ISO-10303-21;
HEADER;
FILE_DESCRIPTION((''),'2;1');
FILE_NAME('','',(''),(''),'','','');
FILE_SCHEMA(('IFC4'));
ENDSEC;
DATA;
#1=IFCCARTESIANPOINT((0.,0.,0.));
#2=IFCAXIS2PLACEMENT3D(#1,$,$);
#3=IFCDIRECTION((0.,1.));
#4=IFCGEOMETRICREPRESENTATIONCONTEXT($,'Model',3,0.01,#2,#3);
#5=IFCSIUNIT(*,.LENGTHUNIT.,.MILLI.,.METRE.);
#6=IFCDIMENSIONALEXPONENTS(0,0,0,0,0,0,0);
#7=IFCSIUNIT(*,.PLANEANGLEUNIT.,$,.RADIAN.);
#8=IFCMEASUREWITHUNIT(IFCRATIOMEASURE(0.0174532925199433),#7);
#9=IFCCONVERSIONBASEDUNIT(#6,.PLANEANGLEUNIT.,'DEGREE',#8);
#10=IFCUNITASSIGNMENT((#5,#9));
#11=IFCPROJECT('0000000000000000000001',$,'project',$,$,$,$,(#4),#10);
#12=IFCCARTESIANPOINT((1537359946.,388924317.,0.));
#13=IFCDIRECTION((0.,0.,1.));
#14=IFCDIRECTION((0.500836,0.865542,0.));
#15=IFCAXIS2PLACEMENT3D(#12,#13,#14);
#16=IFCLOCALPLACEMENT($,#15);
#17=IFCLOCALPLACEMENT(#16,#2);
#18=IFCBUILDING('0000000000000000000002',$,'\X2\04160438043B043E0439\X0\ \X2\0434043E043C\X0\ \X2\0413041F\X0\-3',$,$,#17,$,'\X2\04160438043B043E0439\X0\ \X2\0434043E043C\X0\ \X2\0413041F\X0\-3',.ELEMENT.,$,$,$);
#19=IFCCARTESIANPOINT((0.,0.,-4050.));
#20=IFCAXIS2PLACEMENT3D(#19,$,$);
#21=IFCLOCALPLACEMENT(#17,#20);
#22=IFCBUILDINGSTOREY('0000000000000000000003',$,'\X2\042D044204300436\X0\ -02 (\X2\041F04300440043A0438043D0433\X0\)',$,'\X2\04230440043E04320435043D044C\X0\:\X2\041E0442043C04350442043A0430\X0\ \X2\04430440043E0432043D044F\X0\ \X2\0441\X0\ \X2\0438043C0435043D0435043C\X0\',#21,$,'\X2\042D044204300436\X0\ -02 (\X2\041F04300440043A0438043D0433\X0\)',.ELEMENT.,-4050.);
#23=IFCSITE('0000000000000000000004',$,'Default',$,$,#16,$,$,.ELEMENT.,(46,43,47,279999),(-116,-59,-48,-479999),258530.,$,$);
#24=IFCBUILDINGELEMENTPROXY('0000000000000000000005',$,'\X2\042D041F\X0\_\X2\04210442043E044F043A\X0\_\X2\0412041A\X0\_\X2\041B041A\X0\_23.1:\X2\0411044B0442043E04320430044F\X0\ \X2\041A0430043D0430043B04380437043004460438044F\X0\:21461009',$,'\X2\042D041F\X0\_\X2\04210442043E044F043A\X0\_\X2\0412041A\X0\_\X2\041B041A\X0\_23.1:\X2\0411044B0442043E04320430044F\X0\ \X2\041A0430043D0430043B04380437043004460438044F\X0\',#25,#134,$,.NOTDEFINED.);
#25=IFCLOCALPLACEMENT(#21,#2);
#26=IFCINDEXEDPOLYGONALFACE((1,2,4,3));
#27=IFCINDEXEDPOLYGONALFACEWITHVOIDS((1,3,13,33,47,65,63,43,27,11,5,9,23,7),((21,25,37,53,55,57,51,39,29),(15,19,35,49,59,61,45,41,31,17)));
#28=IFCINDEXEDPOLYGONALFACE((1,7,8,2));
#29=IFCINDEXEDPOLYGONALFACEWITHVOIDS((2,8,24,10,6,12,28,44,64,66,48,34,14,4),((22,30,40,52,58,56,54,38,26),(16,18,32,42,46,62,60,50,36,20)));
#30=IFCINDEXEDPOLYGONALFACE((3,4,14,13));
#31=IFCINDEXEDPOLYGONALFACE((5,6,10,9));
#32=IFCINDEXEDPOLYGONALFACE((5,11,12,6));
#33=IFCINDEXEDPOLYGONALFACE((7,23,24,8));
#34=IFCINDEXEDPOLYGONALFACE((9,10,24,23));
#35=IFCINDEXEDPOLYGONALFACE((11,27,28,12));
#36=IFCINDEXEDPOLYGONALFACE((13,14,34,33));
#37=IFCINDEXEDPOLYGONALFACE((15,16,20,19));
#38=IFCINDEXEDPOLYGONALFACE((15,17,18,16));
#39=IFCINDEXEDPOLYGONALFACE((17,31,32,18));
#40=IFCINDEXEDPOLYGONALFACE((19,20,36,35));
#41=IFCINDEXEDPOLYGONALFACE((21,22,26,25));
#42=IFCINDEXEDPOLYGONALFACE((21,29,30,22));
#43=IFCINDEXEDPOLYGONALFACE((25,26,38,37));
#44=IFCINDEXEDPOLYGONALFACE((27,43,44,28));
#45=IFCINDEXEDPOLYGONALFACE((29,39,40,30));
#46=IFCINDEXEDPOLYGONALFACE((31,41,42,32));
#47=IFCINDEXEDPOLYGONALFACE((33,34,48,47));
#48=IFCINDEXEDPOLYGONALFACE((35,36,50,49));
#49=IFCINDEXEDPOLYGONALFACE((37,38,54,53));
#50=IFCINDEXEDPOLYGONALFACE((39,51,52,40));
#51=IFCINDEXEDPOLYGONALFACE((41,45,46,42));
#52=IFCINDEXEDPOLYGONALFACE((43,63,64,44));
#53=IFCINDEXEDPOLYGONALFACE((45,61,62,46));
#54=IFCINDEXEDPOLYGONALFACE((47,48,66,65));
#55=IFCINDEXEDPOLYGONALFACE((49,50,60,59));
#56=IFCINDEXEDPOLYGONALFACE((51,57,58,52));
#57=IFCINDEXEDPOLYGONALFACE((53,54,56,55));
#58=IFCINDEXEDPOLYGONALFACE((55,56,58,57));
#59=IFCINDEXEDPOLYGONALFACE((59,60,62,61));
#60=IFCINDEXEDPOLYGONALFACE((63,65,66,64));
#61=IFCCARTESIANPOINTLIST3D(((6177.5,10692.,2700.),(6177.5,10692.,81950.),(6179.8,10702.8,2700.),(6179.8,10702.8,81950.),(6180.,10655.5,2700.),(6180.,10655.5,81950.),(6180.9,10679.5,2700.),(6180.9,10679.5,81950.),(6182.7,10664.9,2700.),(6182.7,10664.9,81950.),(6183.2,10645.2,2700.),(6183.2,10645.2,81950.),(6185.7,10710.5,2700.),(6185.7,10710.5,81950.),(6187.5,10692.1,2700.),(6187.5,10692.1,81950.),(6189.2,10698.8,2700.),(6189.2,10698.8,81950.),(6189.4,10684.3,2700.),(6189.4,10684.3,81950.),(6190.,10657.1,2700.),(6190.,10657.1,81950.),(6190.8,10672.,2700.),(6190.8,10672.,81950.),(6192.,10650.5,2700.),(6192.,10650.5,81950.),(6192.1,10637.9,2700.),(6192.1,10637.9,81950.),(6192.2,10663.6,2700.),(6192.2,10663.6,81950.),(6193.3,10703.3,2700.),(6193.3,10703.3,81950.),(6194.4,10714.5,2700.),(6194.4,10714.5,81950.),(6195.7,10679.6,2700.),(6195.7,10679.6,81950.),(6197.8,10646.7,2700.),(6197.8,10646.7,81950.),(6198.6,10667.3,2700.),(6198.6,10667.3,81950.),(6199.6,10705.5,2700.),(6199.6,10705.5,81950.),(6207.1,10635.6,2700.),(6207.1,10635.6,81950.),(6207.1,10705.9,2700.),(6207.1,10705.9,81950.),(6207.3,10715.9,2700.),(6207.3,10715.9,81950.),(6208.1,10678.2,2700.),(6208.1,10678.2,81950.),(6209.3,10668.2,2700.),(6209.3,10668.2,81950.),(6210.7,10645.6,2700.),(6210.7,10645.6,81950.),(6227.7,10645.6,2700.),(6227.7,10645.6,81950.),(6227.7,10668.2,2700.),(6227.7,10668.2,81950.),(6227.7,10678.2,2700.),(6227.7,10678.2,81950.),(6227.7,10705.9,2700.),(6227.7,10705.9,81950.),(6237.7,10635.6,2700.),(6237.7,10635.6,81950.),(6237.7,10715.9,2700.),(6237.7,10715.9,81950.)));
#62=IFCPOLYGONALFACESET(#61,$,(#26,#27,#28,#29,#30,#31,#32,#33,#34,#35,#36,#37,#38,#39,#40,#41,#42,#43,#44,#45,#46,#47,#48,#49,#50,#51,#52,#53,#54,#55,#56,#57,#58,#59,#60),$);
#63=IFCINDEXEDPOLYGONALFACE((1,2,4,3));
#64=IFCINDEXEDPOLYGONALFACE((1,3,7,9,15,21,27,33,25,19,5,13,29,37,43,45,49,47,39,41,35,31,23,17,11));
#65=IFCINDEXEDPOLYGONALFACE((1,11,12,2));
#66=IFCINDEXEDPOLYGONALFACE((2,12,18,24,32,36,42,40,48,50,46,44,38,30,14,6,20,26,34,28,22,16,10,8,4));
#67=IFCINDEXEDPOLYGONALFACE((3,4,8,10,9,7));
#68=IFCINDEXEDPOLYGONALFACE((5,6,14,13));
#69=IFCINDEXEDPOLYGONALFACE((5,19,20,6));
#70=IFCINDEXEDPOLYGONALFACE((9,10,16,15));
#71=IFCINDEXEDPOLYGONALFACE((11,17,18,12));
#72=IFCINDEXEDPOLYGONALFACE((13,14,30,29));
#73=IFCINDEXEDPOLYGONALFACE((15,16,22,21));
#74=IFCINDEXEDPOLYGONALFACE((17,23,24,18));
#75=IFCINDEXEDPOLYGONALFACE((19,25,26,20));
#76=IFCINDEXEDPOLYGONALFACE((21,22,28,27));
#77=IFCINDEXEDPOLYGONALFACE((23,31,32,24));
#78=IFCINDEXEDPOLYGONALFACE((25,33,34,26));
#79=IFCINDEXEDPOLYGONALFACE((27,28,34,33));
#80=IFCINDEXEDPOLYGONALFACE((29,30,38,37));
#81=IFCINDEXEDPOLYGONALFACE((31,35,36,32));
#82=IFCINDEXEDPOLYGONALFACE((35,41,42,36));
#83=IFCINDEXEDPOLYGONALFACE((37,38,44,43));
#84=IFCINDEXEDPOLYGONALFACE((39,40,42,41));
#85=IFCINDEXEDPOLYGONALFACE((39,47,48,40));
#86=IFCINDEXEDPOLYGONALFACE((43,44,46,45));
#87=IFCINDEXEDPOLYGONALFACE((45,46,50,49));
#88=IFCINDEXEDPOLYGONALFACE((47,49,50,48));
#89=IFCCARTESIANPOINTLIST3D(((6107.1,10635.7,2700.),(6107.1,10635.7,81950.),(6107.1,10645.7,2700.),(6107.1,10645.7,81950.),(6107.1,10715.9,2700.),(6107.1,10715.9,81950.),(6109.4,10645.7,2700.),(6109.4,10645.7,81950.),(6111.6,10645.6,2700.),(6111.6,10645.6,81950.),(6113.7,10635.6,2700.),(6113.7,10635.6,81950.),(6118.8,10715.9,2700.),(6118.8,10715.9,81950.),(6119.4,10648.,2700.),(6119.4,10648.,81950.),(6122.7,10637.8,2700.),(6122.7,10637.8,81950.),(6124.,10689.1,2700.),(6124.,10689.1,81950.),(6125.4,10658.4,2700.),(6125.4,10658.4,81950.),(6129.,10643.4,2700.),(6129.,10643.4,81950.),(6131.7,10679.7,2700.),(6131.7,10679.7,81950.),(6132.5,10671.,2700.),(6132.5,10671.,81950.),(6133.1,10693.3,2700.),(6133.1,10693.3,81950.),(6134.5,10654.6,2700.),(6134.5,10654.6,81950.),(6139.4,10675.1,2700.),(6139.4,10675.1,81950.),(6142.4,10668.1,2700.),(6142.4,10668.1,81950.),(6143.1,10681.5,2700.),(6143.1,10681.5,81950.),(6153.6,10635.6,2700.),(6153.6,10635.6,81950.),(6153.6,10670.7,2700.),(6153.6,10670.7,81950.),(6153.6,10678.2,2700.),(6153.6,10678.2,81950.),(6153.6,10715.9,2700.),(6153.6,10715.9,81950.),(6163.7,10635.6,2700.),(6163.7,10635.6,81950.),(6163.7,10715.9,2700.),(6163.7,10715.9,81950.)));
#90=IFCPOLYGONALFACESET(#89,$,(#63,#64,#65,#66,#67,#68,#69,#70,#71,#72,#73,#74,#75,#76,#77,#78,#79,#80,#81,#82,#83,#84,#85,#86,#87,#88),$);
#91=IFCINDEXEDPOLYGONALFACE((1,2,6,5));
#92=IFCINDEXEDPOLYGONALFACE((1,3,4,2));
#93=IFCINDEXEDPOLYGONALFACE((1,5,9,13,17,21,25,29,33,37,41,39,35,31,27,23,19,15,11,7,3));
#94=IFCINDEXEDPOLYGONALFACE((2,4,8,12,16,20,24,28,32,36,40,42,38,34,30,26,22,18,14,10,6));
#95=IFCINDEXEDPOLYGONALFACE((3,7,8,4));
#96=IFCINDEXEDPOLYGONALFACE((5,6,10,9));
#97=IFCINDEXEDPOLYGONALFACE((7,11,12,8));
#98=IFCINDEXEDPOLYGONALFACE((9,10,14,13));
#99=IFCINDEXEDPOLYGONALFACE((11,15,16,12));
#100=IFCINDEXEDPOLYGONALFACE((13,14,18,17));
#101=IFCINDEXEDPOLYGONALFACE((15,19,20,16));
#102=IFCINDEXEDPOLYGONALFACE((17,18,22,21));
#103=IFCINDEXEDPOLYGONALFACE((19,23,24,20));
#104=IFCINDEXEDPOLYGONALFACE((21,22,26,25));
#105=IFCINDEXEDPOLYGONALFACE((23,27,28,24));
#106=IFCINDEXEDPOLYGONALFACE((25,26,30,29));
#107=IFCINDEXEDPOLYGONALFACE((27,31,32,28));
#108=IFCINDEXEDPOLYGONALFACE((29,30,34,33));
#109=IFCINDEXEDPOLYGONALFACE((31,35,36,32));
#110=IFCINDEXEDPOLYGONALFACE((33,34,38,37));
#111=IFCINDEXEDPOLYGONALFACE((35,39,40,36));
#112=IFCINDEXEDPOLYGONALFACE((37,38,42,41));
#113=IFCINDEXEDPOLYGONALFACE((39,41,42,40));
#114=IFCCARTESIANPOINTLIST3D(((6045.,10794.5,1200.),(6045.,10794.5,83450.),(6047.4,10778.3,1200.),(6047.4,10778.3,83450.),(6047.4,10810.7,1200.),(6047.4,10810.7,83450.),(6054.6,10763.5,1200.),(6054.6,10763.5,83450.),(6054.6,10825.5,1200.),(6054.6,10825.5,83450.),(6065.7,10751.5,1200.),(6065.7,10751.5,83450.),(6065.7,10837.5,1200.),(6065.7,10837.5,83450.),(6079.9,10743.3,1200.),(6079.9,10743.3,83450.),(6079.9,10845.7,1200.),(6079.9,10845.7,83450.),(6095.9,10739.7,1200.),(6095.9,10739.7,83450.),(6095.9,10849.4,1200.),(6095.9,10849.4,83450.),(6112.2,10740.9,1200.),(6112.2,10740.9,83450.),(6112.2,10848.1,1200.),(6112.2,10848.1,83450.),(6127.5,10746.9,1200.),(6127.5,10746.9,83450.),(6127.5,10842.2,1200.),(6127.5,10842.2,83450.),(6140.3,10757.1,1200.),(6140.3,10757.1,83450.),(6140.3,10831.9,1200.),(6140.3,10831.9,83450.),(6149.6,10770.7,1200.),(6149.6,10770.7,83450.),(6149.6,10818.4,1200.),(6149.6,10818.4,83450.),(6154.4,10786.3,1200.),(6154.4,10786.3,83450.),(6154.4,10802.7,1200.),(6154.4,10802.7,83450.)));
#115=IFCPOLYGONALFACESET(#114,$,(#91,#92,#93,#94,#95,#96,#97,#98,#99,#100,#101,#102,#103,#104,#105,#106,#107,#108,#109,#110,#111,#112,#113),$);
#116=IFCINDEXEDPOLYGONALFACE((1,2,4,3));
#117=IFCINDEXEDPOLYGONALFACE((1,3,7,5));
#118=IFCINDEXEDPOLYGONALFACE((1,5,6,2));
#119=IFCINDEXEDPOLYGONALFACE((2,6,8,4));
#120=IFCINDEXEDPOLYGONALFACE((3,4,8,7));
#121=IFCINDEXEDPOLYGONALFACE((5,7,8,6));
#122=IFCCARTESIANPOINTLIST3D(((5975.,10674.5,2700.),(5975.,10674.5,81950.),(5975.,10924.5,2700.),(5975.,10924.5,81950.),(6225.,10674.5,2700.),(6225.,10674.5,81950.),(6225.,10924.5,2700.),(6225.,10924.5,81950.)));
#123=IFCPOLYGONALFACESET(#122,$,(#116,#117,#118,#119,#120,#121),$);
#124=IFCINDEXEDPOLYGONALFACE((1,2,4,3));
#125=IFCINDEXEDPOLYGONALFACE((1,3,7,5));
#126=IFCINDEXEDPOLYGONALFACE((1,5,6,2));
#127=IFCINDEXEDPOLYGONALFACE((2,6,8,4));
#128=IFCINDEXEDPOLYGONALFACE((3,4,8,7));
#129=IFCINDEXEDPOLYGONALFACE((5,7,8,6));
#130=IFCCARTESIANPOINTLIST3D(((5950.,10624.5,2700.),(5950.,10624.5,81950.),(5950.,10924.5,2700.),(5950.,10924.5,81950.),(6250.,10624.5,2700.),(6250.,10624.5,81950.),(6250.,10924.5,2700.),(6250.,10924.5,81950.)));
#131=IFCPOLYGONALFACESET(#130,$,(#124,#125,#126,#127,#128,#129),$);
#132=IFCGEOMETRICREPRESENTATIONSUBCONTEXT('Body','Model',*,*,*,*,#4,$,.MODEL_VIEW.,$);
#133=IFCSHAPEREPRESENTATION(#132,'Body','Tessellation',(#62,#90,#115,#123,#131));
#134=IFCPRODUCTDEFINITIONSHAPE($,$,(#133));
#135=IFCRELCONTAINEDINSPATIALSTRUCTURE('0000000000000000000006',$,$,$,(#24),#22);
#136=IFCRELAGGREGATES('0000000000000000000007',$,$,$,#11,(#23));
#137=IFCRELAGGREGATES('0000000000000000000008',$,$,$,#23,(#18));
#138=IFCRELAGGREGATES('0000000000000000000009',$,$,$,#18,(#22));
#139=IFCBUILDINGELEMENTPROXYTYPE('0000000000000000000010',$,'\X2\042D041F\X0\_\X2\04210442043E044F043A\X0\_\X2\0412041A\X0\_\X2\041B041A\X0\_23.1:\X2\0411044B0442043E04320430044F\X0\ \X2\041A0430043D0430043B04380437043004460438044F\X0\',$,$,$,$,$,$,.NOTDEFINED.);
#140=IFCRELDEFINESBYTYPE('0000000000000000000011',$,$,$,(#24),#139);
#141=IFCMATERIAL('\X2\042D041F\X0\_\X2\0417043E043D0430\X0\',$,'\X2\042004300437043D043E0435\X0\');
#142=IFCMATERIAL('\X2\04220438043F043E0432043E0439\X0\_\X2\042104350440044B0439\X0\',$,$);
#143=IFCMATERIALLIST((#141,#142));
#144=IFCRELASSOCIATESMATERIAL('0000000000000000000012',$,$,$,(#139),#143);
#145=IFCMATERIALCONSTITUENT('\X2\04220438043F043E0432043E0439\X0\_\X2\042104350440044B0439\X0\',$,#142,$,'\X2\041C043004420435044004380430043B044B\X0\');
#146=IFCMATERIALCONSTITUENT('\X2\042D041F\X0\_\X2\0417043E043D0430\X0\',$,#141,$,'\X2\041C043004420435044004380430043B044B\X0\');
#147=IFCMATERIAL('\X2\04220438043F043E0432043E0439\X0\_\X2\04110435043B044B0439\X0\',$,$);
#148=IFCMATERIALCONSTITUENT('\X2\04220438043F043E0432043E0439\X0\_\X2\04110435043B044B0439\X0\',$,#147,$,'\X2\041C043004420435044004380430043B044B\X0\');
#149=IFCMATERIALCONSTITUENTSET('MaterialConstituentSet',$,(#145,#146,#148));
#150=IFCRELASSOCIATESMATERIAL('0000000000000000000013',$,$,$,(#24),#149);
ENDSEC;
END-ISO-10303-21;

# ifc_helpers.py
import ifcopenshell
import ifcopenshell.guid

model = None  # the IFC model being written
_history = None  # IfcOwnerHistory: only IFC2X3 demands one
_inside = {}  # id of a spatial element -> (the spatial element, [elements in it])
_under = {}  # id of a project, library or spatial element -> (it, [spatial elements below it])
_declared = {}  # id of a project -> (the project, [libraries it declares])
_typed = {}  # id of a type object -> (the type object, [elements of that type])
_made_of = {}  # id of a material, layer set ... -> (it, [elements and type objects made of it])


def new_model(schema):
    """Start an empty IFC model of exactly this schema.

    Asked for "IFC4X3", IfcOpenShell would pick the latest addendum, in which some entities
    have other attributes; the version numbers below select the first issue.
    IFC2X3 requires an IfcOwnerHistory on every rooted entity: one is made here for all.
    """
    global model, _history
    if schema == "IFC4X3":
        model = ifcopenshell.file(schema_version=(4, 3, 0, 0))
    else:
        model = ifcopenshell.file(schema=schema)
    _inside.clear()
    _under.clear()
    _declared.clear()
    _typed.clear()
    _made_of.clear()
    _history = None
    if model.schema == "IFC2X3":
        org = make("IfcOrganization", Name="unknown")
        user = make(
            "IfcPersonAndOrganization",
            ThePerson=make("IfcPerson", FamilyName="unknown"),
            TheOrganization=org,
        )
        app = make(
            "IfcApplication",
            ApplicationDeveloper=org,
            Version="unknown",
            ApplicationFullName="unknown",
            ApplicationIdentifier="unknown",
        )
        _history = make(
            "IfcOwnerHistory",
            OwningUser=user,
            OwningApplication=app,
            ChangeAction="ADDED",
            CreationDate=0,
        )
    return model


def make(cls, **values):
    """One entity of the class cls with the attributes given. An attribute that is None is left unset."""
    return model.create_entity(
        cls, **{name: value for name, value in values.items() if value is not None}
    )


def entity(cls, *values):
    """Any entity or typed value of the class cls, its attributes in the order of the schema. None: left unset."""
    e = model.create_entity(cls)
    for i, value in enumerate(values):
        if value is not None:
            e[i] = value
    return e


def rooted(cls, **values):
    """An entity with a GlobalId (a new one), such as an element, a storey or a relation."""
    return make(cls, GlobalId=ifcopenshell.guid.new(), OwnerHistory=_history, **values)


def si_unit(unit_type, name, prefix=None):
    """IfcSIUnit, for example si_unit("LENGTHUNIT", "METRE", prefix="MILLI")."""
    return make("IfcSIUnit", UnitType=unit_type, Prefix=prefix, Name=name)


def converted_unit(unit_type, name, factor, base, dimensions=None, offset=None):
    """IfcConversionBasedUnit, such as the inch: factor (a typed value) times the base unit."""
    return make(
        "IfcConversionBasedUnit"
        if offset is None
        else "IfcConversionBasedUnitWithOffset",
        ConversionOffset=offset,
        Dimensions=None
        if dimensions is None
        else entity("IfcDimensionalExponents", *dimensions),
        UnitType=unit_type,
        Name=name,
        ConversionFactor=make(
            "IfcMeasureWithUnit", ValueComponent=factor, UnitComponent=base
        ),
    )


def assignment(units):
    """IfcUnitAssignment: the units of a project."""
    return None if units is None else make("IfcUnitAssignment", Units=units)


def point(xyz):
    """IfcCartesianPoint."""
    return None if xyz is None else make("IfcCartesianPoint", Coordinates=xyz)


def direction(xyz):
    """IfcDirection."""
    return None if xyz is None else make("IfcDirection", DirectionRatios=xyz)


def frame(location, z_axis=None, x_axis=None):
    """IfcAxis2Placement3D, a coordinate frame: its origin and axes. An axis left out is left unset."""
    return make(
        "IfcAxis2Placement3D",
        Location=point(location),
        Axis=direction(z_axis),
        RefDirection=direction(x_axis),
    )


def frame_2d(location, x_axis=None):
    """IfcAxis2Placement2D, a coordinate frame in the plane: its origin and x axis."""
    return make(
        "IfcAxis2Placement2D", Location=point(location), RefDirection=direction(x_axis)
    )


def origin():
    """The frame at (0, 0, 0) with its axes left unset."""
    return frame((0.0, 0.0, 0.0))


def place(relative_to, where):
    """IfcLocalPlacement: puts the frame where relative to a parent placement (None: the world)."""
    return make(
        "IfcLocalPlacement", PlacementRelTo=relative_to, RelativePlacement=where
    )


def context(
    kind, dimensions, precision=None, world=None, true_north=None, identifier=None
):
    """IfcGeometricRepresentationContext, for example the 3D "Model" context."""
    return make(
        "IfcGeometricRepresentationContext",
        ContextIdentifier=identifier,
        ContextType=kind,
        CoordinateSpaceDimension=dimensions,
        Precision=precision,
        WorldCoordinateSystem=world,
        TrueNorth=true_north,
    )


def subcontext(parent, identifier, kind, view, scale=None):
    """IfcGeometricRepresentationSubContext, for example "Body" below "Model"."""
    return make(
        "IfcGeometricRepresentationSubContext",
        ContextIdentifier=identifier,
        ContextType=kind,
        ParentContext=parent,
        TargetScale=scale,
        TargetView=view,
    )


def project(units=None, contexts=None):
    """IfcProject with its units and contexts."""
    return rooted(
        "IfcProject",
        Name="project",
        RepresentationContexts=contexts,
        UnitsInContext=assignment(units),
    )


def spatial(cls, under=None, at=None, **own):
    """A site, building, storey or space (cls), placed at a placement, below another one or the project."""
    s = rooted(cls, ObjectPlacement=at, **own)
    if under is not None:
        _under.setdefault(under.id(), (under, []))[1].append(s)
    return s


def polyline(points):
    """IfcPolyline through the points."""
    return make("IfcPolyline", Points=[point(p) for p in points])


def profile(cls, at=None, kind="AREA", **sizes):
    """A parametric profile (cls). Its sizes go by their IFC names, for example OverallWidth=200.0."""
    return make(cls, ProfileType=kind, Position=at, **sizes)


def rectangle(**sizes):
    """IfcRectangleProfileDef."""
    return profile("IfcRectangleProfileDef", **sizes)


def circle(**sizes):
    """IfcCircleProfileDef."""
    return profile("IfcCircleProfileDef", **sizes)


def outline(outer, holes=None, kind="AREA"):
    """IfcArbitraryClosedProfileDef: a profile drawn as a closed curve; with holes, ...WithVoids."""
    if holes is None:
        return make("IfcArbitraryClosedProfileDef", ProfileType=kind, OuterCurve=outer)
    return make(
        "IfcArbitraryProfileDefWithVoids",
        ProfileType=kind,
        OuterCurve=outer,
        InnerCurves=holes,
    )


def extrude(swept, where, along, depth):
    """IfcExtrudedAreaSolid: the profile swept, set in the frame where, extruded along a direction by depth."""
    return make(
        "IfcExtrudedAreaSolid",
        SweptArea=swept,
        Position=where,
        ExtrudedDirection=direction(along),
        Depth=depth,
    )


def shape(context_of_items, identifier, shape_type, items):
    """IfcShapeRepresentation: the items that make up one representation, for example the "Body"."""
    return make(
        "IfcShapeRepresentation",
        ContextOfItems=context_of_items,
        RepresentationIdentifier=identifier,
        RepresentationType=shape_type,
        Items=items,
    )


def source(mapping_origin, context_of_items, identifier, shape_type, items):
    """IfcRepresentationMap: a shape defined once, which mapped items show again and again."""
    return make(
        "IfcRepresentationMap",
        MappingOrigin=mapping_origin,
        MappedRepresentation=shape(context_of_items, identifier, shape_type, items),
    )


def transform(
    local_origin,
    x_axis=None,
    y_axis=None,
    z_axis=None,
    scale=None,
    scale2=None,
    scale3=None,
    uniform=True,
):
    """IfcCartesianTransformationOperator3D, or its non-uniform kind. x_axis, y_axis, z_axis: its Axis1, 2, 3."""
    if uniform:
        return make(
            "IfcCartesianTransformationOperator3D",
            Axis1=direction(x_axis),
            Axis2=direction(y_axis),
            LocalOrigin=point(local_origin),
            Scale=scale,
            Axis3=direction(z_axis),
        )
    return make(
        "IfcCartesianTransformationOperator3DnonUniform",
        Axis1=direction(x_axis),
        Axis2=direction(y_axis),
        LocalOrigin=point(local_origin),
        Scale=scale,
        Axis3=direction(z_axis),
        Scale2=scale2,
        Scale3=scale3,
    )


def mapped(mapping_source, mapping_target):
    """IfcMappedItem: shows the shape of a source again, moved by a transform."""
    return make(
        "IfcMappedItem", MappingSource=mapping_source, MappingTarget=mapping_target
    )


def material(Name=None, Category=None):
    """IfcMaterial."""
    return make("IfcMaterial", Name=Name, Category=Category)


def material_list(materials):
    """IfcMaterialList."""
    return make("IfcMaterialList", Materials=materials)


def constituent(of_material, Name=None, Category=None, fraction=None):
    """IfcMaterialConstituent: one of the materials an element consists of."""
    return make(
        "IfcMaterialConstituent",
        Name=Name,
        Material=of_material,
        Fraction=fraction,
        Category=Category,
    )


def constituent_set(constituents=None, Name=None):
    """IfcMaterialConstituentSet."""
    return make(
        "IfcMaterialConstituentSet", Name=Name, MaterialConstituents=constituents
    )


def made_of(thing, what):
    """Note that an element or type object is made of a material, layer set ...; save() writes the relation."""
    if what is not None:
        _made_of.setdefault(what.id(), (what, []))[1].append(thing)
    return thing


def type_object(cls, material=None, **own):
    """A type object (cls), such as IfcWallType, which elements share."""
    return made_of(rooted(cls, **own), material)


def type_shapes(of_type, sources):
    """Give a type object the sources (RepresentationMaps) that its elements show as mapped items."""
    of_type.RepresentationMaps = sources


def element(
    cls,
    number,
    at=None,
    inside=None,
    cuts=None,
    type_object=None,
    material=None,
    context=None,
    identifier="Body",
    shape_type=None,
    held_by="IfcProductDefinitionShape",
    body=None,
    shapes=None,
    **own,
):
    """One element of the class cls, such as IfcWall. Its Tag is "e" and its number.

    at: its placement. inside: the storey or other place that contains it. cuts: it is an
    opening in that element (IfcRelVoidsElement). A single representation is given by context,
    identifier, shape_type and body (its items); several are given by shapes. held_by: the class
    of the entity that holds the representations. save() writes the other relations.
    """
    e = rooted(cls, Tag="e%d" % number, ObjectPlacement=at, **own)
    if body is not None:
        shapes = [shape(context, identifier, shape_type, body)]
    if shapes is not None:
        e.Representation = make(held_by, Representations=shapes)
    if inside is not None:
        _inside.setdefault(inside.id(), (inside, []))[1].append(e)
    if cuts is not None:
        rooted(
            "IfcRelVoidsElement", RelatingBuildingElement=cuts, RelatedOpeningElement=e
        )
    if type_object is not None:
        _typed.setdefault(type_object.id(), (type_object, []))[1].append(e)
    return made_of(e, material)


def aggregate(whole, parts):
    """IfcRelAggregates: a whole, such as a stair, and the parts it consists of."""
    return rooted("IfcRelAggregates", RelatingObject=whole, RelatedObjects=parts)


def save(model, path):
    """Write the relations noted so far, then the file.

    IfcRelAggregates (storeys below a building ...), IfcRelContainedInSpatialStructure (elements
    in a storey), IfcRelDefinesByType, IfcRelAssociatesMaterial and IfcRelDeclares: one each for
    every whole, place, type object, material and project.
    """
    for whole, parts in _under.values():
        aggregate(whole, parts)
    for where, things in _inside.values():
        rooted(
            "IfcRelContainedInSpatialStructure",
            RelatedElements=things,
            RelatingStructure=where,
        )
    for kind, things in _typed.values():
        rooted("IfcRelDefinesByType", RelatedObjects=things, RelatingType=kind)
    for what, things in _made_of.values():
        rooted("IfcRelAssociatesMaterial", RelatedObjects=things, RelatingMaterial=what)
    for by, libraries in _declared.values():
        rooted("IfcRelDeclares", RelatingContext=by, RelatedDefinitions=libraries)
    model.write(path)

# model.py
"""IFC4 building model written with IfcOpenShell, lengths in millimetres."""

from ifc_helpers import new_model, entity, si_unit, converted_unit, direction, frame, frame_2d, origin, place, context, subcontext, project, spatial, polyline, rectangle, circle, outline, extrude, source, transform, mapped, material, material_list, constituent, constituent_set, type_object, type_shapes, element, save


model = new_model("IFC4")

# Units and contexts
model_context = context("Model", 3, precision=0.01, world=origin(), true_north=direction((0.0, 1.0)))
body_context = subcontext(model_context, "Body", "Model", "MODEL_VIEW")
ifc_project = project(units=[si_unit("LENGTHUNIT", "METRE", prefix="MILLI"), converted_unit("PLANEANGLEUNIT", "DEGREE", entity("IfcRatioMeasure", 0.0174532925199433), si_unit("PLANEANGLEUNIT", "RADIAN"), dimensions=[0, 0, 0, 0, 0, 0, 0])], contexts=[model_context])

# Site, building, storey
site_placement = place(None, frame((1537359946.0, 388924317.0, 0.0), z_axis=(0.0, 0.0, 1.0), x_axis=(0.500836, 0.865542, 0.0)))
site = spatial("IfcSite", under=ifc_project, at=site_placement, Name="Default", CompositionType="ELEMENT", RefLatitude=(46, 43, 47, 279999), RefLongitude=(-116, -59, -48, -479999), RefElevation=258530.0)
building_placement = place(site_placement, origin())
building = spatial("IfcBuilding", under=site, at=building_placement, Name="Жилой дом ГП-3", LongName="Жилой дом ГП-3", CompositionType="ELEMENT")
storey_placement = place(building_placement, frame((0.0, 0.0, -4050.0)))
storey = spatial("IfcBuildingStorey", under=building, at=storey_placement, Name="Этаж -02 (Паркинг)", ObjectType="Уровень:Отметка уровня с именем", LongName="Этаж -02 (Паркинг)", CompositionType="ELEMENT", Elevation=-4050.0)

# Building element proxy
ifc_material_1 = material(Name="ЭП_Зона", Category="Разное")
ifc_material_2 = material(Name="Типовой_Белый")
ifc_material_3 = material(Name="Типовой_Серый")
ifc_material_list_1 = material_list([ifc_material_1, ifc_material_3])
building_element_proxy_type_1 = type_object("IfcBuildingElementProxyType", Name="ЭП_Стояк_ВК_ЛК_23.1:Бытовая Канализация", PredefinedType="NOTDEFINED", material=ifc_material_list_1)
shared_shape_1 = source(origin(), body_context, "Body", "SweptSolid", [
    extrude(outline(polyline([(-42.2, -39.0), (-11.8, -39.0), (1.1, -37.6), (9.8, -33.5), (15.7, -25.8), (18.0, -15.0), (14.6, -2.5), (4.7, 5.0), (12.8, 12.1), (15.5, 21.5), (12.3, 31.8), (3.4, 39.0), (-11.6, 41.4), (-42.2, 41.4), (-42.2, -39.0)]), holes=[polyline([(-32.2, 8.8), (-32.2, 31.4), (-15.2, 31.4), (-2.3, 30.3), (3.5, 26.4), (5.5, 19.9), (3.3, 13.3), (-3.1, 9.6), (-13.9, 8.8), (-32.2, 8.8)]), polyline([(-32.2, -28.9), (-32.2, -1.3), (-12.6, -1.3), (-0.2, -2.6), (6.1, -7.3), (8.0, -15.1), (6.3, -21.9), (2.2, -26.3), (-4.1, -28.5), (-11.6, -28.9), (-32.2, -28.9)])]), frame((54.5, -52.4, -1350.0)), (0.0, 0.0, 1.0), 79250.0),
    extrude(outline(polyline([(-32.1, -31.9), (48.3, -31.9), (48.3, -21.8), (10.6, -21.8), (13.8, -11.4), (25.6, -1.3), (48.3, 13.0), (48.3, 24.6), (21.4, 7.7), (12.0, 0.1), (7.4, -7.7), (3.3, -0.7), (-9.3, 6.4), (-19.7, 12.3), (-22.1, 20.2), (-22.0, 22.4), (-22.0, 24.6), (-32.0, 24.6), (-32.1, 18.0), (-29.9, 9.0), (-24.3, 2.8), (-13.1, -2.8), (0.4, -10.6), (3.0, -21.8), (-32.1, -21.8), (-32.1, -31.9)])), frame((118.2, -43.1, -1350.0), z_axis=(0.0, 0.0, 1.0), x_axis=(0.0, -1.0, 0.0)), (0.0, 0.0, 1.0), 79250.0),
    extrude(circle(Radius=55.0, at=frame_2d((0.0, 0.0), x_axis=(1.0, 0.0))), frame((150.0, -170.0, -2850.0)), (0.0, 0.0, 1.0), 82250.0),
    extrude(rectangle(XDim=250.0, YDim=250.0, at=frame_2d((0.0, 0.0), x_axis=(1.0, 0.0))), frame((150.0, -175.0, -1350.0)), (0.0, 0.0, 1.0), 79250.0),
    extrude(rectangle(XDim=300.0, YDim=300.0, at=frame_2d((0.0, 0.0), x_axis=(1.0, 0.0))), frame((150.0, -150.0, -1350.0)), (0.0, 0.0, 1.0), 79250.0),
])
type_shapes(building_element_proxy_type_1, [shared_shape_1])
ifc_constituent_1 = constituent(ifc_material_3, Name="Типовой_Серый", Category="Материалы")
ifc_constituent_2 = constituent(ifc_material_1, Name="ЭП_Зона", Category="Материалы")
ifc_constituent_3 = constituent(ifc_material_2, Name="Типовой_Белый", Category="Материалы")
ifc_constituent_set_1 = constituent_set(constituents=[ifc_constituent_1, ifc_constituent_2, ifc_constituent_3], Name="MaterialConstituentSet")
proxy_1_placement = place(storey_placement, frame((6250.0, 10624.5, 4050.0), z_axis=(0.0, 0.0, 1.0), x_axis=(-1.0, 0.0, 0.0)))
element("IfcBuildingElementProxy", 1, at=proxy_1_placement, inside=storey, type_object=building_element_proxy_type_1, material=ifc_constituent_set_1, Name="ЭП_Стояк_ВК_ЛК_23.1:Бытовая Канализация:21461009", ObjectType="ЭП_Стояк_ВК_ЛК_23.1:Бытовая Канализация", PredefinedType="NOTDEFINED", context=body_context, shape_type="MappedRepresentation", body=[
    mapped(shared_shape_1, transform((0.0, 0.0, 0.0), scale=1.0)),
])

save(model, "model.ifc")
